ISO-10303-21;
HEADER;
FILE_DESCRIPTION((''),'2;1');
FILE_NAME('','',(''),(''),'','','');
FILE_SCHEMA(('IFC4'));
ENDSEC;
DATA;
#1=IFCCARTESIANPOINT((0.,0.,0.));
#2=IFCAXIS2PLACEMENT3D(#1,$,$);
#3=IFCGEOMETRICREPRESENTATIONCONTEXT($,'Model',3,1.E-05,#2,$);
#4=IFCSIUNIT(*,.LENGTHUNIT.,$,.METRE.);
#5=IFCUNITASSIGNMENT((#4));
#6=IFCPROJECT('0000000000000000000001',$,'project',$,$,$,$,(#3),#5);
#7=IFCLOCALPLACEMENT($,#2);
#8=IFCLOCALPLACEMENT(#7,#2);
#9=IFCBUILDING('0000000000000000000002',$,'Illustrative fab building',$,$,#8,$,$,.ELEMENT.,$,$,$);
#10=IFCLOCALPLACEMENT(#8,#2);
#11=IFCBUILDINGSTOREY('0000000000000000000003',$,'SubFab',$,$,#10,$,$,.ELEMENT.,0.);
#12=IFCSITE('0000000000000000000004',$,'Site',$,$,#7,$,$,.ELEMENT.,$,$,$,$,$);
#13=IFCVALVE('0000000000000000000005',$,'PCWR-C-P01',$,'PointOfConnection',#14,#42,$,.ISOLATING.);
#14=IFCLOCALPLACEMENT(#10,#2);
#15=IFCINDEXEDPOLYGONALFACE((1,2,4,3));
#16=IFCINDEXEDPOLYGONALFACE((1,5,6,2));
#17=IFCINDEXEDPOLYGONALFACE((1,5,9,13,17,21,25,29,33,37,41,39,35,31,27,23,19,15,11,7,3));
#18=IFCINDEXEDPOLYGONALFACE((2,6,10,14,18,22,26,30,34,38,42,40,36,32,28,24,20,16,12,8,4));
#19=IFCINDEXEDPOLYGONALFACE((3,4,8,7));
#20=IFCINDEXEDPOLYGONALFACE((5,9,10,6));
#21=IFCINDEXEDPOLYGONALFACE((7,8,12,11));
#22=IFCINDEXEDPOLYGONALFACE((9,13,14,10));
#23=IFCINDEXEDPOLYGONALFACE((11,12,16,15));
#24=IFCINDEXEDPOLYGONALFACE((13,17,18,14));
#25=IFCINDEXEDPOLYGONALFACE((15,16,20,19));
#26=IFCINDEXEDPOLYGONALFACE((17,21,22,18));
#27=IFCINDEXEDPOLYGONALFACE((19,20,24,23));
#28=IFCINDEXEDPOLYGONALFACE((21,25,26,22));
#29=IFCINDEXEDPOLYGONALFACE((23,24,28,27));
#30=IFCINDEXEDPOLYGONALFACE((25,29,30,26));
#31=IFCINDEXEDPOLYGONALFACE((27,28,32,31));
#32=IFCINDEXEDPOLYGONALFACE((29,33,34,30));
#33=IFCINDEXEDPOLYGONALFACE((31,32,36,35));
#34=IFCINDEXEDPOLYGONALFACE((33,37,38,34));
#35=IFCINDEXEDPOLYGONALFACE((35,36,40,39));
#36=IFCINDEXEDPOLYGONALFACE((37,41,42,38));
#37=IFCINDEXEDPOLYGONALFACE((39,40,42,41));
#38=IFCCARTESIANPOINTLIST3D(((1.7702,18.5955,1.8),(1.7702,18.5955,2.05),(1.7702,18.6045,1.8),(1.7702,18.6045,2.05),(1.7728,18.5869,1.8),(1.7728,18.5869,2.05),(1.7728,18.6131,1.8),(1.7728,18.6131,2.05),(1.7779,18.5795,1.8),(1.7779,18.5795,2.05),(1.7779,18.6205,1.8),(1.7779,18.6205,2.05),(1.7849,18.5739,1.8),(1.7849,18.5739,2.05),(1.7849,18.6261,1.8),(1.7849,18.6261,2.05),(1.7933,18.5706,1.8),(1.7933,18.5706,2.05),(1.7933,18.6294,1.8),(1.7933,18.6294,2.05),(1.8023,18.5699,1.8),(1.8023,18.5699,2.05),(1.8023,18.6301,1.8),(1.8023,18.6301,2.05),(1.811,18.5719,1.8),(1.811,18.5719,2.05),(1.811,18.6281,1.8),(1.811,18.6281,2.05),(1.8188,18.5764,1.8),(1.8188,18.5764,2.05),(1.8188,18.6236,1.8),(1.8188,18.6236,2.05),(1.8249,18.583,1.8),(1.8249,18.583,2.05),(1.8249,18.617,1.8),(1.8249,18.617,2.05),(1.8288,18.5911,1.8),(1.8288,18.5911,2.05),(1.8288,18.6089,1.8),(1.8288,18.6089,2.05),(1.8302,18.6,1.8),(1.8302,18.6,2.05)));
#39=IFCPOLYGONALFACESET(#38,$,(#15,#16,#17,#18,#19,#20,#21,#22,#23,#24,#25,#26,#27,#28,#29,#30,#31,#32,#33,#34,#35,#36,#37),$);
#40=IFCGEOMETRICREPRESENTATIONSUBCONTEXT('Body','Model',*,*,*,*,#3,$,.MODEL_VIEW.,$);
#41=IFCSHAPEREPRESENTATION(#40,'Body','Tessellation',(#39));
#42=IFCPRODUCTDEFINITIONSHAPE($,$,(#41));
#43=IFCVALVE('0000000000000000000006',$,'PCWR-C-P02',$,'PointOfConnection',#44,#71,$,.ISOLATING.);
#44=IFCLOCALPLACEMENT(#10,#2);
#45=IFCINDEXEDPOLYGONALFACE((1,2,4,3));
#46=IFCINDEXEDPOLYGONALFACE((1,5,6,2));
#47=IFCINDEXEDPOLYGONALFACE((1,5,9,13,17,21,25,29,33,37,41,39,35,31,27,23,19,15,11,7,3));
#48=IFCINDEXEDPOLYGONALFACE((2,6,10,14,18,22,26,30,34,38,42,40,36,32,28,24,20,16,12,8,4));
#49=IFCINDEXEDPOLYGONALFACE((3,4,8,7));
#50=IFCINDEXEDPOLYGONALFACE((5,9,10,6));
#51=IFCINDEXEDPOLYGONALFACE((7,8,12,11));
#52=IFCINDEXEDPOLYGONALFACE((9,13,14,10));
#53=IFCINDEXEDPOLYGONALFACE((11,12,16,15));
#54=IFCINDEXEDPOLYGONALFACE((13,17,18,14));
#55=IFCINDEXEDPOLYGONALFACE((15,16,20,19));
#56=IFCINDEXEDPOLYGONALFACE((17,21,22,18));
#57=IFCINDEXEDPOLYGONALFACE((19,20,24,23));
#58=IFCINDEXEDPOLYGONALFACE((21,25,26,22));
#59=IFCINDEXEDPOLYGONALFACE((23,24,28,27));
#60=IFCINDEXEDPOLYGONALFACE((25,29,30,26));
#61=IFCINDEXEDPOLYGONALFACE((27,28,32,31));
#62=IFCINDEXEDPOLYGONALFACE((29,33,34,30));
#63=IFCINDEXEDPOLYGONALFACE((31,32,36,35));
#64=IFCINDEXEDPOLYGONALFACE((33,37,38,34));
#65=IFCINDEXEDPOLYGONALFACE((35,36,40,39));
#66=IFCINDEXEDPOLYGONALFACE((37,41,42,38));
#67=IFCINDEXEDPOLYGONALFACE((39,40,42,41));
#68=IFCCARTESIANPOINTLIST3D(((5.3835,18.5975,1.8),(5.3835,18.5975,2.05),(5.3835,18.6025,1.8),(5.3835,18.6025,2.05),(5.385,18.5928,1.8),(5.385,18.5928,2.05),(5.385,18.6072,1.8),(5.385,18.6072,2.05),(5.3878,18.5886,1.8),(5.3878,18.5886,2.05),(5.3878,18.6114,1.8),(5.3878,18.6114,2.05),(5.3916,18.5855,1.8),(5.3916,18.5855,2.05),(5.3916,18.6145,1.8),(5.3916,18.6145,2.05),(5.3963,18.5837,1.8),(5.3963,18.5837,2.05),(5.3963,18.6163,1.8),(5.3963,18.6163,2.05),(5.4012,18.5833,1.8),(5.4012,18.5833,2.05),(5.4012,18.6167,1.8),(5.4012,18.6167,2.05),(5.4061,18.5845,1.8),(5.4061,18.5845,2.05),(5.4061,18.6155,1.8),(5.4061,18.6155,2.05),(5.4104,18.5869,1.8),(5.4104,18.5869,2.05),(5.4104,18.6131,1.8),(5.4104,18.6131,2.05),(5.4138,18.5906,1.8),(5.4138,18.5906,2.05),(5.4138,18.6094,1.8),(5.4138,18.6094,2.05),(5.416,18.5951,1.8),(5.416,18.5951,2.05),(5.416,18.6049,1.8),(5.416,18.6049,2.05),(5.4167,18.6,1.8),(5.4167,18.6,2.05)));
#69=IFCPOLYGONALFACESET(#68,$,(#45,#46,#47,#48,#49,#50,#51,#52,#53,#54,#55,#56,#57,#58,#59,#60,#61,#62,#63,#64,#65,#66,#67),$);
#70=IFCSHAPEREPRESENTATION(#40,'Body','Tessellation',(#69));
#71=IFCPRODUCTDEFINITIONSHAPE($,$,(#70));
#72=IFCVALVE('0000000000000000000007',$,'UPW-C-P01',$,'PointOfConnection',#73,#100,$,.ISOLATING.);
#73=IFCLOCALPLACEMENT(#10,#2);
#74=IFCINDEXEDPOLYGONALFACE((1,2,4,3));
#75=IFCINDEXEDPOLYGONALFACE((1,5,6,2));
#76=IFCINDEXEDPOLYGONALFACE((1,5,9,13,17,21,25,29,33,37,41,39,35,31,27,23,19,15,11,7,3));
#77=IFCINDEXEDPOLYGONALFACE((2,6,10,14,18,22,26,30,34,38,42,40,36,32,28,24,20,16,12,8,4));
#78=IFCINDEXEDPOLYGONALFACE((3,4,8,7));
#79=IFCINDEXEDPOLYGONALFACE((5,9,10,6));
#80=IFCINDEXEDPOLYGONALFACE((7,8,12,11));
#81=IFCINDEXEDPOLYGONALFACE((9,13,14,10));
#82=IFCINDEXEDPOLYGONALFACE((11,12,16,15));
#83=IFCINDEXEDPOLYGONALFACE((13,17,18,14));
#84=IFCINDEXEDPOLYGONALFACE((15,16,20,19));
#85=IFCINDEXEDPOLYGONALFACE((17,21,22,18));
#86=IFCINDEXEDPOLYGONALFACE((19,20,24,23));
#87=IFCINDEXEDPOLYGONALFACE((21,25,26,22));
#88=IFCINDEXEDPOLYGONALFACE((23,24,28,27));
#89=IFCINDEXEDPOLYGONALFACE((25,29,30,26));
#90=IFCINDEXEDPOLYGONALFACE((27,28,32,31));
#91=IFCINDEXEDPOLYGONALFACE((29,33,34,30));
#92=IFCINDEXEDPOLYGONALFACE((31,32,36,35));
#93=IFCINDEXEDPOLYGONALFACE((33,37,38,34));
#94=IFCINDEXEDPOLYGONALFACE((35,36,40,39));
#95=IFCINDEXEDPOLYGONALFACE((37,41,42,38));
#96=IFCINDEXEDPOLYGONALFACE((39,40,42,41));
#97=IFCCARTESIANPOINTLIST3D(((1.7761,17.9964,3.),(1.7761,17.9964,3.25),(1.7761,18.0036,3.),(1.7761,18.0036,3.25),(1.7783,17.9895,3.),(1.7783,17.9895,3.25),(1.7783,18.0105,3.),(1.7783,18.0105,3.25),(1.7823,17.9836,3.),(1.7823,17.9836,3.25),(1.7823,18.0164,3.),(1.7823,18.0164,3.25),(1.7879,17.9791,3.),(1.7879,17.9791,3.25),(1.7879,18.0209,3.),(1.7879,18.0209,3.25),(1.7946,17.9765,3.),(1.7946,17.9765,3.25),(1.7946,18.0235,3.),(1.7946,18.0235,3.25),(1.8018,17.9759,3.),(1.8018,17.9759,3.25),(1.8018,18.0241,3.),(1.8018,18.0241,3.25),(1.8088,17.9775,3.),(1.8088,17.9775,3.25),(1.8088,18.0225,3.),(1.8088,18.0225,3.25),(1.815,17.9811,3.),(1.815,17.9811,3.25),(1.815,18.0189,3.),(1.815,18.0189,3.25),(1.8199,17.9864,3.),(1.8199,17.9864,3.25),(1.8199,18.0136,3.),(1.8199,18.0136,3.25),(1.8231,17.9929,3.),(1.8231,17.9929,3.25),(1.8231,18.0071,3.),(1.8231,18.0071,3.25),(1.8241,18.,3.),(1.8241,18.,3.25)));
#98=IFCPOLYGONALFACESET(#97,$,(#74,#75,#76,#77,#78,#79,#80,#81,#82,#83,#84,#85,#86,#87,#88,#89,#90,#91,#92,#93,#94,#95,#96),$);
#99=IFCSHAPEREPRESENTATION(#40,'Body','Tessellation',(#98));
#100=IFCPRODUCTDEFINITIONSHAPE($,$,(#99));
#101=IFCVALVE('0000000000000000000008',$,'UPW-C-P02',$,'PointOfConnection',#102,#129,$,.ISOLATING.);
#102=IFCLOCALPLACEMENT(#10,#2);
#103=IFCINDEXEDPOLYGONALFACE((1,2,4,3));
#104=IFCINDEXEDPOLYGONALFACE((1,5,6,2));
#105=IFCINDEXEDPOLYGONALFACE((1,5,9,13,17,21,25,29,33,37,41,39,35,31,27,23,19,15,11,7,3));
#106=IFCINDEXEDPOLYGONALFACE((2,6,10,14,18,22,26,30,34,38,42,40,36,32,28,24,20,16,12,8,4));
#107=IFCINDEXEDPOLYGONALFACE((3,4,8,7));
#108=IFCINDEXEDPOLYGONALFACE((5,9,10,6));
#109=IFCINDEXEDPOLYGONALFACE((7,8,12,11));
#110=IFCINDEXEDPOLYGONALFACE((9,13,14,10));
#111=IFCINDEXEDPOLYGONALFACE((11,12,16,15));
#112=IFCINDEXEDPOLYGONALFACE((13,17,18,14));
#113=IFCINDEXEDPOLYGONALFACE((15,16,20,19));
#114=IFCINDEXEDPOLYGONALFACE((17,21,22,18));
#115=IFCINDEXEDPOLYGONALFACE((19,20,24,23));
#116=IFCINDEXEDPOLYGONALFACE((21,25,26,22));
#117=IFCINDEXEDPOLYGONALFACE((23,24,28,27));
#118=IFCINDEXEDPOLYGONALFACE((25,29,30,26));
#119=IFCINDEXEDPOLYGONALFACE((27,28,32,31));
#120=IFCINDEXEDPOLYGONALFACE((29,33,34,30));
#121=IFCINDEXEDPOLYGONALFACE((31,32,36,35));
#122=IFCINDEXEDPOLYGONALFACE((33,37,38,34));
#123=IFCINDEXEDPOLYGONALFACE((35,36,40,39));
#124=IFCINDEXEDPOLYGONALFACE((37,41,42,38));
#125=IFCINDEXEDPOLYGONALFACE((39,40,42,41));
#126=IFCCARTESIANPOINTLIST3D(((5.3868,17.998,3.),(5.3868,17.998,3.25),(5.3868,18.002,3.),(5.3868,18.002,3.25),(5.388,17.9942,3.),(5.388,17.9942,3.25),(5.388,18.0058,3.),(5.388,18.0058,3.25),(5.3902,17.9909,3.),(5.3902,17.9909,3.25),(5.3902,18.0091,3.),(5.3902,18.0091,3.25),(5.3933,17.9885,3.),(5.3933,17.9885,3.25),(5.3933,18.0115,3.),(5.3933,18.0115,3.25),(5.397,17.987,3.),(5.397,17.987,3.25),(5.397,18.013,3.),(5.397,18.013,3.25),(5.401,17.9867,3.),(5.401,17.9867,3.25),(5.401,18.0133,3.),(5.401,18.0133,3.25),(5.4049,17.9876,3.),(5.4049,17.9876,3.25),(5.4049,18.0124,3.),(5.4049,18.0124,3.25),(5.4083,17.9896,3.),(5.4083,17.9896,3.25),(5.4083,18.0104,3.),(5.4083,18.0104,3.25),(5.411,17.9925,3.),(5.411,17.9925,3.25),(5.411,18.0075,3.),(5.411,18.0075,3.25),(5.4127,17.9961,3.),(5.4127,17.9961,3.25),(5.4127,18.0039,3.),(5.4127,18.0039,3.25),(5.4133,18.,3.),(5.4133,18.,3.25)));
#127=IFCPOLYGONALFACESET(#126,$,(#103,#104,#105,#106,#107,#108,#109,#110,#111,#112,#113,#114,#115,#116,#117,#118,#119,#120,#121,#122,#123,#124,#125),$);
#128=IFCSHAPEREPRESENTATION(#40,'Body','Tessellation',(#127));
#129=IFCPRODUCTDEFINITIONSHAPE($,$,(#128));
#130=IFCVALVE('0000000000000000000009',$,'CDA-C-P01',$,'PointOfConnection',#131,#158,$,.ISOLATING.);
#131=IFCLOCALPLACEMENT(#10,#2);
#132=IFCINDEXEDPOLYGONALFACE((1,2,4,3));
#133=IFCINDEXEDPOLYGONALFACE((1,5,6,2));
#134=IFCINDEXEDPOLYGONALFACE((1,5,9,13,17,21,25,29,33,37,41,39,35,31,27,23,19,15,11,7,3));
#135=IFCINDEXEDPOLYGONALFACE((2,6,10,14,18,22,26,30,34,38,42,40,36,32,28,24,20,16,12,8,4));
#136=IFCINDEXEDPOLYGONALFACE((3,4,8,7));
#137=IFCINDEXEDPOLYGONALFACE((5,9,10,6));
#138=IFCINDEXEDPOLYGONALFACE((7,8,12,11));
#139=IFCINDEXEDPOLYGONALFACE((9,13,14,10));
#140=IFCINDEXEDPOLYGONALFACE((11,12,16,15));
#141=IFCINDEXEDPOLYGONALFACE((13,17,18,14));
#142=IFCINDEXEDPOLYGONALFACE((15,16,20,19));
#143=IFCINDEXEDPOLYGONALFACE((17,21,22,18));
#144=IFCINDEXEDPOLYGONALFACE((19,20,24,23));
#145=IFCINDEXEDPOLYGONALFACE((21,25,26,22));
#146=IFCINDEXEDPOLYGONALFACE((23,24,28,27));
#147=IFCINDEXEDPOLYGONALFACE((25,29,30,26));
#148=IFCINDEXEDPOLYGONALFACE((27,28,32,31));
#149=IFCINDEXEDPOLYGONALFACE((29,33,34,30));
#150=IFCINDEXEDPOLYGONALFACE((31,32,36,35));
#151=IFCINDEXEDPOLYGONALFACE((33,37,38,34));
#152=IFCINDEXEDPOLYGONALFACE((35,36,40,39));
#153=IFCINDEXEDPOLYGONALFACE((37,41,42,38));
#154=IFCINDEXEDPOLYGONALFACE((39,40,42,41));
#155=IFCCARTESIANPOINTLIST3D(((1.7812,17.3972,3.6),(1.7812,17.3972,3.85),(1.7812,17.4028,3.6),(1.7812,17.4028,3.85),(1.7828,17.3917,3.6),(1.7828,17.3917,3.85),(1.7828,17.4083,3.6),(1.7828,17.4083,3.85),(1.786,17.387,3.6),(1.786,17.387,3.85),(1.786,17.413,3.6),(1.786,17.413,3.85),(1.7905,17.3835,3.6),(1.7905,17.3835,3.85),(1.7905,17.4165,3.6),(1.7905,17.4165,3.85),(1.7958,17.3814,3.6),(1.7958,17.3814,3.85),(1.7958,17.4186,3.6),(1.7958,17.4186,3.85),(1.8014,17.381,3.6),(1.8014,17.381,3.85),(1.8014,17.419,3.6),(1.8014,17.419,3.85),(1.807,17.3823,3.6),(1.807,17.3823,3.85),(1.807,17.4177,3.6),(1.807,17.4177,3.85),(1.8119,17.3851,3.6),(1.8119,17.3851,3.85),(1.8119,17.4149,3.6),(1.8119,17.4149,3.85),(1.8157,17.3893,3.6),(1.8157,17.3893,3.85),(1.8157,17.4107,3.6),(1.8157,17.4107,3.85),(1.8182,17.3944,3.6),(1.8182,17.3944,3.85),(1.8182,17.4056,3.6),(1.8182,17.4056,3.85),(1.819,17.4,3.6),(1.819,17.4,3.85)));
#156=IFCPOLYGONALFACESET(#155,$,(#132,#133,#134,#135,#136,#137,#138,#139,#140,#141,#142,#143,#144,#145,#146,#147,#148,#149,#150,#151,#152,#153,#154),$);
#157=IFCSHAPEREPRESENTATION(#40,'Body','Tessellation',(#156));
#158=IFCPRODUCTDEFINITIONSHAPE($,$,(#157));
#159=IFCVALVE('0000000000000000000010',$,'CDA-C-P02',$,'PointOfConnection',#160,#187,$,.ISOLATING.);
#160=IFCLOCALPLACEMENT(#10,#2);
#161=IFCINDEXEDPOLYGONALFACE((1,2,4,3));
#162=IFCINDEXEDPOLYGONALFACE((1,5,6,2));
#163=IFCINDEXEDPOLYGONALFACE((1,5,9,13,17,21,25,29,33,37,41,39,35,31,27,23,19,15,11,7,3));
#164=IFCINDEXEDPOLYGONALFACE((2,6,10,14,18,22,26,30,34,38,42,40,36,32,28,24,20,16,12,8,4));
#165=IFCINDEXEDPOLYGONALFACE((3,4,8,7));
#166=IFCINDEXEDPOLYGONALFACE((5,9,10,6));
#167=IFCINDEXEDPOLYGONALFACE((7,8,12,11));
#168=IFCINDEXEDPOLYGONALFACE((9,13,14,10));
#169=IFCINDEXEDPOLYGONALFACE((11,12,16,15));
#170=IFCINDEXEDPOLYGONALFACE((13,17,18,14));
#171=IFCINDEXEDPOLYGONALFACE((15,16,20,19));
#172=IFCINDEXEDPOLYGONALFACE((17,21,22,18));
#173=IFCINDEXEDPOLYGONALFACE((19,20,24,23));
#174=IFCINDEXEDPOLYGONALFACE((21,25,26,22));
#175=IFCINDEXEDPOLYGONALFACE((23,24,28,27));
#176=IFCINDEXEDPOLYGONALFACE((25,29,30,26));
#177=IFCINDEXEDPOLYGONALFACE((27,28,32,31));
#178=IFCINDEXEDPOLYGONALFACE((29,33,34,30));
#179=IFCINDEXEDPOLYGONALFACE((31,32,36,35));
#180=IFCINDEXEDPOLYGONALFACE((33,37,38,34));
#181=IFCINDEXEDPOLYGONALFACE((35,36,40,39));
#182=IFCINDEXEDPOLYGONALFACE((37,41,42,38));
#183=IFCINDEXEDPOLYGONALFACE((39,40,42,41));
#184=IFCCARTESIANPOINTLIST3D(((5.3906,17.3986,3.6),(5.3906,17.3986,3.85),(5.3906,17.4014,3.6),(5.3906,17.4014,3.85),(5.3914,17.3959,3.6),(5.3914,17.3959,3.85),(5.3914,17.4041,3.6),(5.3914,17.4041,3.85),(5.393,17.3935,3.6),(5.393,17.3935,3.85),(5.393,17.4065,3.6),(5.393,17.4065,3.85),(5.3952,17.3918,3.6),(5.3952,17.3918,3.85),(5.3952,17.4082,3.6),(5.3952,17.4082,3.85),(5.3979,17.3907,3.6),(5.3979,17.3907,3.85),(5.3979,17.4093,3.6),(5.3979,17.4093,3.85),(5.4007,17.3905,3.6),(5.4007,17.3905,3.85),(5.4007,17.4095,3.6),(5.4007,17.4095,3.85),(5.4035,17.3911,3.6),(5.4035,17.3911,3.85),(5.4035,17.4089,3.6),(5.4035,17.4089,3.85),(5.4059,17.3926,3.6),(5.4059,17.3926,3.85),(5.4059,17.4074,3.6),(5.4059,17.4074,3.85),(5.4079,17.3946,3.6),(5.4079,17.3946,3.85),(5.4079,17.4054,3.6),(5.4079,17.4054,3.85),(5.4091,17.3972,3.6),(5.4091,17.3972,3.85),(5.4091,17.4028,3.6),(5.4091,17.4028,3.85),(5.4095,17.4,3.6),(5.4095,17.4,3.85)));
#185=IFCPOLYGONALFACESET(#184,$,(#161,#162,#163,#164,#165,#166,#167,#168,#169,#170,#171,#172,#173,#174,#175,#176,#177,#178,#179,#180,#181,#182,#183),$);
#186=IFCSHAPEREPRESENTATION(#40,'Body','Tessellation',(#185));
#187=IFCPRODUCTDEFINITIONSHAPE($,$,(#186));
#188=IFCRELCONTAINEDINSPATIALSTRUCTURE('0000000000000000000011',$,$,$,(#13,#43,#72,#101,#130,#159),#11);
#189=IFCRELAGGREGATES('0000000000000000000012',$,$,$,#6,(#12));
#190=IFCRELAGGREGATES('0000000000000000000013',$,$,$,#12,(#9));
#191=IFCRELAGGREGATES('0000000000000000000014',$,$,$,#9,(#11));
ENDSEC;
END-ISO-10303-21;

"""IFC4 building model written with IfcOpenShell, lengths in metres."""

from ifc_helpers import new_model, entity, si_unit, frame, origin, place, context, subcontext, project, spatial, element, save


model = new_model("IFC4")

# Units and contexts
model_context = context("Model", 3, precision=1e-05, world=origin())
body_context = subcontext(model_context, "Body", "Model", "MODEL_VIEW")
ifc_project = project(units=[si_unit("LENGTHUNIT", "METRE")], contexts=[model_context])

# Site, building, storey
site_placement = place(None, origin())
site = spatial("IfcSite", under=ifc_project, at=site_placement, Name="Site", CompositionType="ELEMENT")
building_placement = place(site_placement, origin())
building = spatial("IfcBuilding", under=site, at=building_placement, Name="Illustrative fab building", CompositionType="ELEMENT")
storey_placement = place(building_placement, origin())
storey = spatial("IfcBuildingStorey", under=building, at=storey_placement, Name="SubFab", CompositionType="ELEMENT", Elevation=0.0)

# Valves
valve_1_placement = place(storey_placement, frame((1.8, 18.6, 1.8)))
element("IfcValve", 1, at=valve_1_placement, inside=storey, Name="PCWR-C-P01", ObjectType="PointOfConnection", PredefinedType="ISOLATING", context=body_context, shape_type="AdvancedSweptSolid", body=[
    entity("IfcSweptDiskSolid", entity("IfcPolyline", [entity("IfcCartesianPoint", [0.0, 0.0, 0.0]), entity("IfcCartesianPoint", [0.0, 0.0, 0.25])]), 0.0302),
])
valve_2_placement = place(storey_placement, frame((5.4, 18.6, 1.8)))
element("IfcValve", 2, at=valve_2_placement, inside=storey, Name="PCWR-C-P02", ObjectType="PointOfConnection", PredefinedType="ISOLATING", context=body_context, shape_type="AdvancedSweptSolid", body=[
    entity("IfcSweptDiskSolid", entity("IfcPolyline", [entity("IfcCartesianPoint", [0.0, 0.0, 0.0]), entity("IfcCartesianPoint", [0.0, 0.0, 0.25])]), 0.0167),
])
valve_3_placement = place(storey_placement, frame((1.8, 18.0, 3.0)))
element("IfcValve", 3, at=valve_3_placement, inside=storey, Name="UPW-C-P01", ObjectType="PointOfConnection", PredefinedType="ISOLATING", context=body_context, shape_type="AdvancedSweptSolid", body=[
    entity("IfcSweptDiskSolid", entity("IfcPolyline", [entity("IfcCartesianPoint", [0.0, 0.0, 0.0]), entity("IfcCartesianPoint", [0.0, 0.0, 0.25])]), 0.0241),
])
valve_4_placement = place(storey_placement, frame((5.4, 18.0, 3.0)))
element("IfcValve", 4, at=valve_4_placement, inside=storey, Name="UPW-C-P02", ObjectType="PointOfConnection", PredefinedType="ISOLATING", context=body_context, shape_type="AdvancedSweptSolid", body=[
    entity("IfcSweptDiskSolid", entity("IfcPolyline", [entity("IfcCartesianPoint", [0.0, 0.0, 0.0]), entity("IfcCartesianPoint", [0.0, 0.0, 0.25])]), 0.0133),
])
valve_5_placement = place(storey_placement, frame((1.8, 17.4, 3.6)))
element("IfcValve", 5, at=valve_5_placement, inside=storey, Name="CDA-C-P01", ObjectType="PointOfConnection", PredefinedType="ISOLATING", context=body_context, shape_type="AdvancedSweptSolid", body=[
    entity("IfcSweptDiskSolid", entity("IfcPolyline", [entity("IfcCartesianPoint", [0.0, 0.0, 0.0]), entity("IfcCartesianPoint", [0.0, 0.0, 0.25])]), 0.019),
])
valve_6_placement = place(storey_placement, frame((5.4, 17.4, 3.6)))
element("IfcValve", 6, at=valve_6_placement, inside=storey, Name="CDA-C-P02", ObjectType="PointOfConnection", PredefinedType="ISOLATING", context=body_context, shape_type="AdvancedSweptSolid", body=[
    entity("IfcSweptDiskSolid", entity("IfcPolyline", [entity("IfcCartesianPoint", [0.0, 0.0, 0.0]), entity("IfcCartesianPoint", [0.0, 0.0, 0.25])]), 0.0095),
])

save(model, "model.ifc")
